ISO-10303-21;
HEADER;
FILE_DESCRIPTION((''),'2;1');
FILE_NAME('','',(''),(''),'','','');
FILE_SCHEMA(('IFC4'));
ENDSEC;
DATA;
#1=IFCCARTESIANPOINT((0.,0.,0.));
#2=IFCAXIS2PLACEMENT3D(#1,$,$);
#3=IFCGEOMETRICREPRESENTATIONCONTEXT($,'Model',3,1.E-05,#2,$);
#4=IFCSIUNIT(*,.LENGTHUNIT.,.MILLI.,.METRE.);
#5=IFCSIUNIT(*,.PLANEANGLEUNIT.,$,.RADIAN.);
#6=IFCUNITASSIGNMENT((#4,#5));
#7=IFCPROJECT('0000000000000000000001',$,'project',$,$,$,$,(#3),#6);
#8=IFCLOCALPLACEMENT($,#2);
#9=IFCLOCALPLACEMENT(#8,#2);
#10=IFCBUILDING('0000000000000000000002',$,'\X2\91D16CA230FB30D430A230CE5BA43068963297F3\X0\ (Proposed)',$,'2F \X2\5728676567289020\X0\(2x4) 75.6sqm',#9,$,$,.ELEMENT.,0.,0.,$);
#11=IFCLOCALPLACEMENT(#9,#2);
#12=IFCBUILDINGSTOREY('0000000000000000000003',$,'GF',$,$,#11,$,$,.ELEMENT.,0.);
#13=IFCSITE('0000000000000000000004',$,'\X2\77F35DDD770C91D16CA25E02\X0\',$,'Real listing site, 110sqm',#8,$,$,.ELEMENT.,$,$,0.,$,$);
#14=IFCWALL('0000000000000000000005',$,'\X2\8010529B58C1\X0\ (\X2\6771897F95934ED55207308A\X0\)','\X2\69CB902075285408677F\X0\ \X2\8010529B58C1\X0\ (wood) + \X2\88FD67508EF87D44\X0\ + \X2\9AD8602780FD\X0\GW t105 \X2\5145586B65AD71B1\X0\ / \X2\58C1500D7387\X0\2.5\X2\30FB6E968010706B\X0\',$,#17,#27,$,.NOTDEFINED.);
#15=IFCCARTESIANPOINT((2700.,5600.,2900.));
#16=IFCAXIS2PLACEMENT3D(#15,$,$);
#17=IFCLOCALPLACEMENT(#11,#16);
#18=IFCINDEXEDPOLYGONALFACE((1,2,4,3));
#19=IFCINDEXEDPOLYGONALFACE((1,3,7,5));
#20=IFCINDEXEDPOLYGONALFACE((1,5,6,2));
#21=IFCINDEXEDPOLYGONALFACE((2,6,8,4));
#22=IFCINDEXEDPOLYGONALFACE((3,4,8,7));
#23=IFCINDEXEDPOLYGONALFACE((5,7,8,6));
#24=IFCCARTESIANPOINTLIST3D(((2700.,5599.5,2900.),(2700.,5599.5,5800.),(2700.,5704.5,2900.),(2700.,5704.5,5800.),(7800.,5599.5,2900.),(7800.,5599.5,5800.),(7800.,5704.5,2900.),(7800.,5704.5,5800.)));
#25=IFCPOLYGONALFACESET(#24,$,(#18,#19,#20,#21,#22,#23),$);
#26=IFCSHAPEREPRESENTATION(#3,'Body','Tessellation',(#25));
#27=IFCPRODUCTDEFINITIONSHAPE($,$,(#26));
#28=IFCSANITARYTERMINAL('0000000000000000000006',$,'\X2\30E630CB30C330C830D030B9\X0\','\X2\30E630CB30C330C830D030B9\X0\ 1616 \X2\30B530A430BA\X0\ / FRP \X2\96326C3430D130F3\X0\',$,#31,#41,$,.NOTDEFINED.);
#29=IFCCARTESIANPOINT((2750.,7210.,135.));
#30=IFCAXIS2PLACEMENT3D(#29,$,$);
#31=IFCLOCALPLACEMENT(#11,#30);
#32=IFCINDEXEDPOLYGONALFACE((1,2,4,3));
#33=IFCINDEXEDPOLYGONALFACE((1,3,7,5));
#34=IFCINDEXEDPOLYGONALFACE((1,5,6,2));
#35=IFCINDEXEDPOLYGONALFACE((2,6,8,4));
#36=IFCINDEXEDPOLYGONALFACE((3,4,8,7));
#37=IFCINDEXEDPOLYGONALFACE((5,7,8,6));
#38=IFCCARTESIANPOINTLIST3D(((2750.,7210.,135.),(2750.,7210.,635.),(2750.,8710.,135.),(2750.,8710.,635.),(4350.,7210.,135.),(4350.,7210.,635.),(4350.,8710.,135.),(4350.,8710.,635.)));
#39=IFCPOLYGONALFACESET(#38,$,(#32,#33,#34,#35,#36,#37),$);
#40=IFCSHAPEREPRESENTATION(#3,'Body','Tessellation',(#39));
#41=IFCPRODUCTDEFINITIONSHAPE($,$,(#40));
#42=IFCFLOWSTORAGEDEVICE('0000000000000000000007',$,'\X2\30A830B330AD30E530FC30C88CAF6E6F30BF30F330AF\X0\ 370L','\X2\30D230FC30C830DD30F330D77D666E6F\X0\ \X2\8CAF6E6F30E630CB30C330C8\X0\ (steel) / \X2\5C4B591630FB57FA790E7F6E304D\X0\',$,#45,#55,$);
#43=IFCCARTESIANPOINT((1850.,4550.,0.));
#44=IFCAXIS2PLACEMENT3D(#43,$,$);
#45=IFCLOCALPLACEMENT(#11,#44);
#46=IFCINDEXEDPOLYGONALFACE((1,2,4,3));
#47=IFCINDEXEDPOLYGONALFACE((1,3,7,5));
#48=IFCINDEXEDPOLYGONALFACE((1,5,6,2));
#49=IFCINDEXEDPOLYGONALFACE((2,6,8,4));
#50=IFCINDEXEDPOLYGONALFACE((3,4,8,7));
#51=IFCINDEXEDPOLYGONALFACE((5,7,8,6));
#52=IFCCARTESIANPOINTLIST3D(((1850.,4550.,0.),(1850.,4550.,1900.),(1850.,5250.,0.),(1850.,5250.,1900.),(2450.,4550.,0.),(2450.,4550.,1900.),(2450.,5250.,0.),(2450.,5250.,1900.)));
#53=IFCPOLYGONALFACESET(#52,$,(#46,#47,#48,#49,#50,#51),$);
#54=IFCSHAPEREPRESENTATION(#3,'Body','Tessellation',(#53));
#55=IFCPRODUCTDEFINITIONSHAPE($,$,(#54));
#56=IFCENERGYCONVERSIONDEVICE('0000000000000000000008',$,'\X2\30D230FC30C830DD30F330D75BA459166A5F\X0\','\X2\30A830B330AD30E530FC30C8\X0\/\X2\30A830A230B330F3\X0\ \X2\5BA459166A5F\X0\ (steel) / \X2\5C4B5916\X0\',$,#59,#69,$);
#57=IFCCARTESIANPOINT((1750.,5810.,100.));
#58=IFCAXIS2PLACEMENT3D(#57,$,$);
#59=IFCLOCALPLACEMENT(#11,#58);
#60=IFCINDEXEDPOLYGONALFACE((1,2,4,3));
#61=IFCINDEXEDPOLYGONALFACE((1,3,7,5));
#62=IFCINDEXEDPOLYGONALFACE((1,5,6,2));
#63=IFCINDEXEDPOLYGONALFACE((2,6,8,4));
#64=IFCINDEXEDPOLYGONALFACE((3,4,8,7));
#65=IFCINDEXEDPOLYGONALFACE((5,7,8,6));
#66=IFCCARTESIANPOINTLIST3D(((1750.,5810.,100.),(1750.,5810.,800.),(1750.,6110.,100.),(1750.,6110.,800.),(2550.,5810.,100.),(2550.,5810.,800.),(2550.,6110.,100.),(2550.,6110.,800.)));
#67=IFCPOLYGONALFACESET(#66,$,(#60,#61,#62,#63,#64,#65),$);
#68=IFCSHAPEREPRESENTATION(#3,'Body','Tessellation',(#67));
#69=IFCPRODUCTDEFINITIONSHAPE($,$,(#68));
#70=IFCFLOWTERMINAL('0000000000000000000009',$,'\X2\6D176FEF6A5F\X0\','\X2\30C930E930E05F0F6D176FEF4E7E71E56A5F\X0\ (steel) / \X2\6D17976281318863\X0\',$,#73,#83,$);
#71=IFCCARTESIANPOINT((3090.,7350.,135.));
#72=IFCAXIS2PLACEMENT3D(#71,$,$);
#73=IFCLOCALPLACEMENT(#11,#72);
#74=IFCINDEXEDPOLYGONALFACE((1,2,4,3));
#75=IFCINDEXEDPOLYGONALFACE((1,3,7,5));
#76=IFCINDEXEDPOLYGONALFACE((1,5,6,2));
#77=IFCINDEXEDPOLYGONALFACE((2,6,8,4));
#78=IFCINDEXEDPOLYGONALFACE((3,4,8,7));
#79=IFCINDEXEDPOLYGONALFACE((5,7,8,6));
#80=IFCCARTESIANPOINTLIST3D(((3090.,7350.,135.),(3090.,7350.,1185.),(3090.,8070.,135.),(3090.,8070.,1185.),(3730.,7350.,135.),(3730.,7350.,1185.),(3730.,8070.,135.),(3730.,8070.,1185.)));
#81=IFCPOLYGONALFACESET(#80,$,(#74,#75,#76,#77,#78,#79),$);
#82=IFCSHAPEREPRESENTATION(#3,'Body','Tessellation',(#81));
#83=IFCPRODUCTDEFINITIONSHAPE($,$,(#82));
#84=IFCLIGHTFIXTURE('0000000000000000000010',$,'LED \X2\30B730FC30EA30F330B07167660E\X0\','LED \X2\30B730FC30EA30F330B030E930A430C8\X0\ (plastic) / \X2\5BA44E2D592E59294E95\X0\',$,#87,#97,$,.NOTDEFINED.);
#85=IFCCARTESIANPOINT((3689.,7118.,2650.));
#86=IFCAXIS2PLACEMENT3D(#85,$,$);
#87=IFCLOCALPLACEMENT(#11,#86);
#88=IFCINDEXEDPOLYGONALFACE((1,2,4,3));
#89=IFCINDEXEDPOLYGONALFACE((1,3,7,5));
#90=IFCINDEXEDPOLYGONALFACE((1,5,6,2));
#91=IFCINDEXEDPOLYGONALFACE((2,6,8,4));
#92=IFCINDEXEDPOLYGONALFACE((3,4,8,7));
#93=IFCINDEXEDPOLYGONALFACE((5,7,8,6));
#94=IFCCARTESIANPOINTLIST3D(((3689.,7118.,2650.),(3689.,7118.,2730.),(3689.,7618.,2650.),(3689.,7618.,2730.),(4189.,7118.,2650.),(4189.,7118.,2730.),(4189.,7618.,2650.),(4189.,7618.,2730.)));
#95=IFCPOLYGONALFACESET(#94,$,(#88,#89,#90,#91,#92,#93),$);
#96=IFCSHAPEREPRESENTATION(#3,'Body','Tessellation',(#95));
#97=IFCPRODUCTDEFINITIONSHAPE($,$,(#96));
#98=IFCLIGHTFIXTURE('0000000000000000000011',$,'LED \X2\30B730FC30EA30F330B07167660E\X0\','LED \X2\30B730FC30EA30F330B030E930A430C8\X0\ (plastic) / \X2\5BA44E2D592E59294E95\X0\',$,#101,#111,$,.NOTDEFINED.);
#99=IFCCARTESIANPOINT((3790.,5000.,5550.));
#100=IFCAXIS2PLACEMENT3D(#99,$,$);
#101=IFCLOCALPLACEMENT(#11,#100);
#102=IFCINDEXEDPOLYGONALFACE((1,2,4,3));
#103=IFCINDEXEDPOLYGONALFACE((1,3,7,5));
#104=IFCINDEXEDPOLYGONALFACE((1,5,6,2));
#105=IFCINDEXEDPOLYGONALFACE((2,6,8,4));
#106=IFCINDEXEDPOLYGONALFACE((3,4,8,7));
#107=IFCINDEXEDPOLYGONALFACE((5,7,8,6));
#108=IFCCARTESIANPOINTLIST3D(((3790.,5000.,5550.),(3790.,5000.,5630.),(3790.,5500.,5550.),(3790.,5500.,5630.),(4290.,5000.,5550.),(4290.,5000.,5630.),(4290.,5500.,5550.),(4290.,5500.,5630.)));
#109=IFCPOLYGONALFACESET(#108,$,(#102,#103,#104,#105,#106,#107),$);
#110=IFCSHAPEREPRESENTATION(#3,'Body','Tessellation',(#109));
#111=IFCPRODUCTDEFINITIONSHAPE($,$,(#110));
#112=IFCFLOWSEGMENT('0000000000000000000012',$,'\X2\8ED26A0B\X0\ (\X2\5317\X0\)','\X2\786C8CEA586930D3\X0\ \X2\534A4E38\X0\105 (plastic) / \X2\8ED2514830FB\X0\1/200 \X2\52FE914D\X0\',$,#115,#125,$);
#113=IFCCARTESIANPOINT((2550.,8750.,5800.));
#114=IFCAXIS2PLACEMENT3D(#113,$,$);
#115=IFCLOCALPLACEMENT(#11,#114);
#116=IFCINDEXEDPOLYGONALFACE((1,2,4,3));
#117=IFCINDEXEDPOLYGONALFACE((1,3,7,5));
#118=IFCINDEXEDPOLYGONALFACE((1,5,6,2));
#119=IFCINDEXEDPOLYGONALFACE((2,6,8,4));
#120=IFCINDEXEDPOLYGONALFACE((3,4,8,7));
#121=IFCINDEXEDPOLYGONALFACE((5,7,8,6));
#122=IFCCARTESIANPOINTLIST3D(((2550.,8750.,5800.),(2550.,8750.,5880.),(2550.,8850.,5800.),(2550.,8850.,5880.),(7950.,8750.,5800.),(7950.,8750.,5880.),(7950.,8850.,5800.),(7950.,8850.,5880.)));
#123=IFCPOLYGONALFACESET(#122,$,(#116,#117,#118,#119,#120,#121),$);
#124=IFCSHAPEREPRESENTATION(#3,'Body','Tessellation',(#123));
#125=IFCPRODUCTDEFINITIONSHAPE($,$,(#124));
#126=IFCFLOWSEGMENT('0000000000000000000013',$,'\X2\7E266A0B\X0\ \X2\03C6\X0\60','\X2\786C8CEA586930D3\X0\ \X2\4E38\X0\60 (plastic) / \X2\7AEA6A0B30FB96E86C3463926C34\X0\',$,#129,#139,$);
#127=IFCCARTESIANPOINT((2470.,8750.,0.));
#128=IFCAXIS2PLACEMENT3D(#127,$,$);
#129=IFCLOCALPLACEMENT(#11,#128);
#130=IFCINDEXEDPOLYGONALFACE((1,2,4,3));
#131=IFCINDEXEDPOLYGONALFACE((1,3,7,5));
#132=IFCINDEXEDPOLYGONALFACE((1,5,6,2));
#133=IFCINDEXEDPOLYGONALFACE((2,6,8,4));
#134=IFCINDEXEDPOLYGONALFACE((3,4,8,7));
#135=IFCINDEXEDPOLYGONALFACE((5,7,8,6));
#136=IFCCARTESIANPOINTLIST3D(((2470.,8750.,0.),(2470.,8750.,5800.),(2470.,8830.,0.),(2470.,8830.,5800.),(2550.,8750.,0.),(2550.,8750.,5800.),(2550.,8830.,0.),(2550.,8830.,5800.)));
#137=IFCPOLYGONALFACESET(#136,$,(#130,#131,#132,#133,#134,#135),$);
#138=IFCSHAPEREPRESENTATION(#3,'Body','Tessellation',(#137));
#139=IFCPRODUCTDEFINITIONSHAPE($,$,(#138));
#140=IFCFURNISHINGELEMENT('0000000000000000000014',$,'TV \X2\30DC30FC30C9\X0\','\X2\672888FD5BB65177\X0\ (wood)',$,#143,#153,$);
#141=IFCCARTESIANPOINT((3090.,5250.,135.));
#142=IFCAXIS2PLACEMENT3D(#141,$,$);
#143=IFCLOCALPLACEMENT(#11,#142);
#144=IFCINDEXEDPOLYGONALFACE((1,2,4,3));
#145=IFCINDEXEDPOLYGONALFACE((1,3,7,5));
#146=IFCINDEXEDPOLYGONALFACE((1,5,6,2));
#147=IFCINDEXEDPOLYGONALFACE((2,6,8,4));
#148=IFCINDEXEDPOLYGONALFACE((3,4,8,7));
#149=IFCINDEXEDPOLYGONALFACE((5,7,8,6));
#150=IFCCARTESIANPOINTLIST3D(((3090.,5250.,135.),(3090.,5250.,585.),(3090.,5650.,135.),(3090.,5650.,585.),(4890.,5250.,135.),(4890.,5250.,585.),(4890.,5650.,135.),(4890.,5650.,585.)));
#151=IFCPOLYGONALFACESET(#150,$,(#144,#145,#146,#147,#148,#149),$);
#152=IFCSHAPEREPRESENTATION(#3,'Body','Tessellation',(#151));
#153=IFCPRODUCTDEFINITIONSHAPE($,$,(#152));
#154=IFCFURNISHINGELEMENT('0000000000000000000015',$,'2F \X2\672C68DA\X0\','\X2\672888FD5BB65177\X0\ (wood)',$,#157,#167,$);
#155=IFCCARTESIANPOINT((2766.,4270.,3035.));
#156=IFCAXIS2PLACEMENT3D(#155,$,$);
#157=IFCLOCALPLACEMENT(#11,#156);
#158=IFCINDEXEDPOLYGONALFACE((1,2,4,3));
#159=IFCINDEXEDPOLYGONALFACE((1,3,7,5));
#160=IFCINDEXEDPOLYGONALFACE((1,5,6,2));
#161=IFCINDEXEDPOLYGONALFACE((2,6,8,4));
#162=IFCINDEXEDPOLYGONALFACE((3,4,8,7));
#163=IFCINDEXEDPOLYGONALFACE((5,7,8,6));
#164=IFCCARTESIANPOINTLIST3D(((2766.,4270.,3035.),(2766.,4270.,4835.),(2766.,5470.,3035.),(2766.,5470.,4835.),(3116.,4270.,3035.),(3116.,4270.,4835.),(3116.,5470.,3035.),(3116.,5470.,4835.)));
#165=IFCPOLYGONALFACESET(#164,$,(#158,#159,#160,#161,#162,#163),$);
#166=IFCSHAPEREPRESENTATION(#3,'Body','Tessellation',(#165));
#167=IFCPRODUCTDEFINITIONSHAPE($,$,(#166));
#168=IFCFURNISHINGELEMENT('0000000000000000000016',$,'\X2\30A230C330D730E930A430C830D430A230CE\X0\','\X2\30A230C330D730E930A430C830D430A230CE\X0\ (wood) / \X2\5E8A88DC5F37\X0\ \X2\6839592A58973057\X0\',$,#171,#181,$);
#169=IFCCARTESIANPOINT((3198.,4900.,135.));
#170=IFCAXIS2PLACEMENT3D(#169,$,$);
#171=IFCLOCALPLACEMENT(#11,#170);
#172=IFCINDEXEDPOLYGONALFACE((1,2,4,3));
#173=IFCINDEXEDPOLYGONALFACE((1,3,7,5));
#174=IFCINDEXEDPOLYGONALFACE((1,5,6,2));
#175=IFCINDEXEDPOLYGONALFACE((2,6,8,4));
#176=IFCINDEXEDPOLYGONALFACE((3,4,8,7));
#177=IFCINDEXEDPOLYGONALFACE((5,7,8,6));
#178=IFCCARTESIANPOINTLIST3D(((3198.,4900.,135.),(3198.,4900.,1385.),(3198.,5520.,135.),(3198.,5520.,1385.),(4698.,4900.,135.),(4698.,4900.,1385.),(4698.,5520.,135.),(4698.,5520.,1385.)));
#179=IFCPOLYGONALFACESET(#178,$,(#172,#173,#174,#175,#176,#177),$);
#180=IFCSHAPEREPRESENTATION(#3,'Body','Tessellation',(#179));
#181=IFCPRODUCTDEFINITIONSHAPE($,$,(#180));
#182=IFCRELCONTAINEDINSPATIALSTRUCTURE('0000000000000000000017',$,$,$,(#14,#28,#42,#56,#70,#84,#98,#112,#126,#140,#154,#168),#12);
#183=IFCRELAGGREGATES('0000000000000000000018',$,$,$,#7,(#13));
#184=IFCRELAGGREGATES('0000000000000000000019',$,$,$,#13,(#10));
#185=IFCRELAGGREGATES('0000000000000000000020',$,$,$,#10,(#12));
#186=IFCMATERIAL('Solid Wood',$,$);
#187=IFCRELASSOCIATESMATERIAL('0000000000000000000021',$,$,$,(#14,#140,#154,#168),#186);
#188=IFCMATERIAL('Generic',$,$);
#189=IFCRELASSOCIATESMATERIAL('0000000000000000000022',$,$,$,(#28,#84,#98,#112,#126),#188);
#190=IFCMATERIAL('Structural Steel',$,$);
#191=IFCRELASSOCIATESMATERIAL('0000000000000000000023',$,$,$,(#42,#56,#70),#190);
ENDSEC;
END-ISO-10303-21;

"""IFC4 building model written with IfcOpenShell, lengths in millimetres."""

from ifc_helpers import new_model, si_unit, frame, frame_2d, origin, place, context, project, spatial, rectangle, extrude, material, element, save


model = new_model("IFC4")

# Units and contexts
model_context = context("Model", 3, precision=1e-05, world=origin())
ifc_project = project(units=[si_unit("LENGTHUNIT", "METRE", prefix="MILLI"), si_unit("PLANEANGLEUNIT", "RADIAN")], contexts=[model_context])

# Site, building, storey
site_placement = place(None, origin())
site = spatial("IfcSite", under=ifc_project, at=site_placement, Name="石川県金沢市", ObjectType="Real listing site, 110sqm", CompositionType="ELEMENT", RefElevation=0.0)
building_placement = place(site_placement, origin())
building = spatial("IfcBuilding", under=site, at=building_placement, Name="金沢・ピアノ室と防音 (Proposed)", ObjectType="2F 在来木造(2x4) 75.6sqm", CompositionType="ELEMENT", ElevationOfRefHeight=0.0, ElevationOfTerrain=0.0)
storey_placement = place(building_placement, origin())
storey = spatial("IfcBuildingStorey", under=building, at=storey_placement, Name="GF", CompositionType="ELEMENT", Elevation=0.0)

# Shared definitions
ifc_material_1 = material(Name="Solid Wood")

# Wall
wall_1_placement = place(storey_placement, frame((2700.0, 5600.0, 2900.0)))
element("IfcWall", 1, at=wall_1_placement, inside=storey, material=ifc_material_1, Name="耐力壁 (東西間仕切り)", Description="構造用合板 耐力壁 (wood) + 製材軸組 + 高性能GW t105 充填断熱 / 壁倍率2.5・準耐火", PredefinedType="NOTDEFINED", context=model_context, shape_type="SweptSolid", body=[
    extrude(rectangle(XDim=5100.0, YDim=105.0, at=frame_2d((2550.0, 52.0))), frame((2700.0, 5600.0, 2900.0)), (0.0, 0.0, 1.0), 2900.0),
])

# Sanitary terminal
ifc_material_2 = material(Name="Generic")
sanitary_terminal_placement = place(storey_placement, frame((2750.0, 7210.0, 135.0)))
element("IfcSanitaryTerminal", 2, at=sanitary_terminal_placement, inside=storey, material=ifc_material_2, Name="ユニットバス", Description="ユニットバス 1616 サイズ / FRP 防水パン", PredefinedType="NOTDEFINED", context=model_context, shape_type="SweptSolid", body=[
    extrude(rectangle(XDim=1600.0, YDim=1500.0, at=frame_2d((800.0, 750.0))), frame((2750.0, 7210.0, 135.0)), (0.0, 0.0, 1.0), 500.0),
])

# Flow storage device
ifc_material_3 = material(Name="Structural Steel")
flow_storage_device_placement = place(storey_placement, frame((1850.0, 4550.0, 0.0)))
element("IfcFlowStorageDevice", 3, at=flow_storage_device_placement, inside=storey, material=ifc_material_3, Name="エコキュート貯湯タンク 370L", Description="ヒートポンプ給湯 貯湯ユニット (steel) / 屋外・基礎置き", context=model_context, shape_type="SweptSolid", body=[
    extrude(rectangle(XDim=600.0, YDim=700.0, at=frame_2d((300.0, 350.0))), frame((1850.0, 4550.0, 0.0)), (0.0, 0.0, 1.0), 1900.0),
])

# Energy conversion device
energy_conversion_device_placement = place(storey_placement, frame((1750.0, 5810.0, 100.0)))
element("IfcEnergyConversionDevice", 4, at=energy_conversion_device_placement, inside=storey, material=ifc_material_3, Name="ヒートポンプ室外機", Description="エコキュート/エアコン 室外機 (steel) / 屋外", context=model_context, shape_type="SweptSolid", body=[
    extrude(rectangle(XDim=800.0, YDim=300.0, at=frame_2d((400.0, 150.0))), frame((1750.0, 5810.0, 100.0)), (0.0, 0.0, 1.0), 700.0),
])

# Flow terminal
flow_terminal_placement = place(storey_placement, frame((3090.0, 7350.0, 135.0)))
element("IfcFlowTerminal", 5, at=flow_terminal_placement, inside=storey, material=ifc_material_3, Name="洗濯機", Description="ドラム式洗濯乾燥機 (steel) / 洗面脱衣", context=model_context, shape_type="SweptSolid", body=[
    extrude(rectangle(XDim=640.0, YDim=720.0, at=frame_2d((320.0, 360.0))), frame((3090.0, 7350.0, 135.0)), (0.0, 0.0, 1.0), 1050.0),
])

# Light fixtures
light_fixture_1_placement = place(storey_placement, frame((3689.0, 7118.0, 2650.0)))
element("IfcLightFixture", 6, at=light_fixture_1_placement, inside=storey, material=ifc_material_2, Name="LED シーリング照明", Description="LED シーリングライト (plastic) / 室中央天井", PredefinedType="NOTDEFINED", context=model_context, shape_type="SweptSolid", body=[
    extrude(rectangle(XDim=500.0, YDim=500.0, at=frame_2d((250.0, 250.0))), frame((3689.0, 7118.0, 2650.0)), (0.0, 0.0, 1.0), 80.0),
])
light_fixture_2_placement = place(storey_placement, frame((3790.0, 5000.0, 5550.0)))
element("IfcLightFixture", 7, at=light_fixture_2_placement, inside=storey, material=ifc_material_2, Name="LED シーリング照明", Description="LED シーリングライト (plastic) / 室中央天井", PredefinedType="NOTDEFINED", context=model_context, shape_type="SweptSolid", body=[
    extrude(rectangle(XDim=500.0, YDim=500.0, at=frame_2d((250.0, 250.0))), frame((3790.0, 5000.0, 5550.0)), (0.0, 0.0, 1.0), 80.0),
])

# Flow segments
flow_segment_1_placement = place(storey_placement, frame((2550.0, 8750.0, 5800.0)))
element("IfcFlowSegment", 8, at=flow_segment_1_placement, inside=storey, material=ifc_material_2, Name="軒樋 (北)", Description="硬質塩ビ 半丸105 (plastic) / 軒先・1/200 勾配", context=model_context, shape_type="SweptSolid", body=[
    extrude(rectangle(XDim=5400.0, YDim=100.0, at=frame_2d((2700.0, 50.0))), frame((2550.0, 8750.0, 5800.0)), (0.0, 0.0, 1.0), 80.0),
])
flow_segment_2_placement = place(storey_placement, frame((2470.0, 8750.0, 0.0)))
element("IfcFlowSegment", 9, at=flow_segment_2_placement, inside=storey, material=ifc_material_2, Name="縦樋 φ60", Description="硬質塩ビ 丸60 (plastic) / 竪樋・雨水排水", context=model_context, shape_type="SweptSolid", body=[
    extrude(rectangle(XDim=80.0, YDim=80.0, at=frame_2d((40.0, 40.0))), frame((2470.0, 8750.0, 0.0)), (0.0, 0.0, 1.0), 5800.0),
])

# Furnishing elements
furnishing_1_placement = place(storey_placement, frame((3090.0, 5250.0, 135.0)))
element("IfcFurnishingElement", 10, at=furnishing_1_placement, inside=storey, material=ifc_material_1, Name="TV ボード", Description="木製家具 (wood)", context=model_context, shape_type="SweptSolid", body=[
    extrude(rectangle(XDim=1800.0, YDim=400.0, at=frame_2d((900.0, 200.0))), frame((3090.0, 5250.0, 135.0)), (0.0, 0.0, 1.0), 450.0),
])
furnishing_2_placement = place(storey_placement, frame((2766.0, 4270.0, 3035.0)))
element("IfcFurnishingElement", 11, at=furnishing_2_placement, inside=storey, material=ifc_material_1, Name="2F 本棚", Description="木製家具 (wood)", context=model_context, shape_type="SweptSolid", body=[
    extrude(rectangle(XDim=350.0, YDim=1200.0, at=frame_2d((175.0, 600.0))), frame((2766.0, 4270.0, 3035.0)), (0.0, 0.0, 1.0), 1800.0),
])
furnishing_3_placement = place(storey_placement, frame((3198.0, 4900.0, 135.0)))
element("IfcFurnishingElement", 12, at=furnishing_3_placement, inside=storey, material=ifc_material_1, Name="アップライトピアノ", Description="アップライトピアノ (wood) / 床補強 根太増し", context=model_context, shape_type="SweptSolid", body=[
    extrude(rectangle(XDim=1500.0, YDim=620.0, at=frame_2d((750.0, 310.0))), frame((3198.0, 4900.0, 135.0)), (0.0, 0.0, 1.0), 1250.0),
])

save(model, "model.ifc")
